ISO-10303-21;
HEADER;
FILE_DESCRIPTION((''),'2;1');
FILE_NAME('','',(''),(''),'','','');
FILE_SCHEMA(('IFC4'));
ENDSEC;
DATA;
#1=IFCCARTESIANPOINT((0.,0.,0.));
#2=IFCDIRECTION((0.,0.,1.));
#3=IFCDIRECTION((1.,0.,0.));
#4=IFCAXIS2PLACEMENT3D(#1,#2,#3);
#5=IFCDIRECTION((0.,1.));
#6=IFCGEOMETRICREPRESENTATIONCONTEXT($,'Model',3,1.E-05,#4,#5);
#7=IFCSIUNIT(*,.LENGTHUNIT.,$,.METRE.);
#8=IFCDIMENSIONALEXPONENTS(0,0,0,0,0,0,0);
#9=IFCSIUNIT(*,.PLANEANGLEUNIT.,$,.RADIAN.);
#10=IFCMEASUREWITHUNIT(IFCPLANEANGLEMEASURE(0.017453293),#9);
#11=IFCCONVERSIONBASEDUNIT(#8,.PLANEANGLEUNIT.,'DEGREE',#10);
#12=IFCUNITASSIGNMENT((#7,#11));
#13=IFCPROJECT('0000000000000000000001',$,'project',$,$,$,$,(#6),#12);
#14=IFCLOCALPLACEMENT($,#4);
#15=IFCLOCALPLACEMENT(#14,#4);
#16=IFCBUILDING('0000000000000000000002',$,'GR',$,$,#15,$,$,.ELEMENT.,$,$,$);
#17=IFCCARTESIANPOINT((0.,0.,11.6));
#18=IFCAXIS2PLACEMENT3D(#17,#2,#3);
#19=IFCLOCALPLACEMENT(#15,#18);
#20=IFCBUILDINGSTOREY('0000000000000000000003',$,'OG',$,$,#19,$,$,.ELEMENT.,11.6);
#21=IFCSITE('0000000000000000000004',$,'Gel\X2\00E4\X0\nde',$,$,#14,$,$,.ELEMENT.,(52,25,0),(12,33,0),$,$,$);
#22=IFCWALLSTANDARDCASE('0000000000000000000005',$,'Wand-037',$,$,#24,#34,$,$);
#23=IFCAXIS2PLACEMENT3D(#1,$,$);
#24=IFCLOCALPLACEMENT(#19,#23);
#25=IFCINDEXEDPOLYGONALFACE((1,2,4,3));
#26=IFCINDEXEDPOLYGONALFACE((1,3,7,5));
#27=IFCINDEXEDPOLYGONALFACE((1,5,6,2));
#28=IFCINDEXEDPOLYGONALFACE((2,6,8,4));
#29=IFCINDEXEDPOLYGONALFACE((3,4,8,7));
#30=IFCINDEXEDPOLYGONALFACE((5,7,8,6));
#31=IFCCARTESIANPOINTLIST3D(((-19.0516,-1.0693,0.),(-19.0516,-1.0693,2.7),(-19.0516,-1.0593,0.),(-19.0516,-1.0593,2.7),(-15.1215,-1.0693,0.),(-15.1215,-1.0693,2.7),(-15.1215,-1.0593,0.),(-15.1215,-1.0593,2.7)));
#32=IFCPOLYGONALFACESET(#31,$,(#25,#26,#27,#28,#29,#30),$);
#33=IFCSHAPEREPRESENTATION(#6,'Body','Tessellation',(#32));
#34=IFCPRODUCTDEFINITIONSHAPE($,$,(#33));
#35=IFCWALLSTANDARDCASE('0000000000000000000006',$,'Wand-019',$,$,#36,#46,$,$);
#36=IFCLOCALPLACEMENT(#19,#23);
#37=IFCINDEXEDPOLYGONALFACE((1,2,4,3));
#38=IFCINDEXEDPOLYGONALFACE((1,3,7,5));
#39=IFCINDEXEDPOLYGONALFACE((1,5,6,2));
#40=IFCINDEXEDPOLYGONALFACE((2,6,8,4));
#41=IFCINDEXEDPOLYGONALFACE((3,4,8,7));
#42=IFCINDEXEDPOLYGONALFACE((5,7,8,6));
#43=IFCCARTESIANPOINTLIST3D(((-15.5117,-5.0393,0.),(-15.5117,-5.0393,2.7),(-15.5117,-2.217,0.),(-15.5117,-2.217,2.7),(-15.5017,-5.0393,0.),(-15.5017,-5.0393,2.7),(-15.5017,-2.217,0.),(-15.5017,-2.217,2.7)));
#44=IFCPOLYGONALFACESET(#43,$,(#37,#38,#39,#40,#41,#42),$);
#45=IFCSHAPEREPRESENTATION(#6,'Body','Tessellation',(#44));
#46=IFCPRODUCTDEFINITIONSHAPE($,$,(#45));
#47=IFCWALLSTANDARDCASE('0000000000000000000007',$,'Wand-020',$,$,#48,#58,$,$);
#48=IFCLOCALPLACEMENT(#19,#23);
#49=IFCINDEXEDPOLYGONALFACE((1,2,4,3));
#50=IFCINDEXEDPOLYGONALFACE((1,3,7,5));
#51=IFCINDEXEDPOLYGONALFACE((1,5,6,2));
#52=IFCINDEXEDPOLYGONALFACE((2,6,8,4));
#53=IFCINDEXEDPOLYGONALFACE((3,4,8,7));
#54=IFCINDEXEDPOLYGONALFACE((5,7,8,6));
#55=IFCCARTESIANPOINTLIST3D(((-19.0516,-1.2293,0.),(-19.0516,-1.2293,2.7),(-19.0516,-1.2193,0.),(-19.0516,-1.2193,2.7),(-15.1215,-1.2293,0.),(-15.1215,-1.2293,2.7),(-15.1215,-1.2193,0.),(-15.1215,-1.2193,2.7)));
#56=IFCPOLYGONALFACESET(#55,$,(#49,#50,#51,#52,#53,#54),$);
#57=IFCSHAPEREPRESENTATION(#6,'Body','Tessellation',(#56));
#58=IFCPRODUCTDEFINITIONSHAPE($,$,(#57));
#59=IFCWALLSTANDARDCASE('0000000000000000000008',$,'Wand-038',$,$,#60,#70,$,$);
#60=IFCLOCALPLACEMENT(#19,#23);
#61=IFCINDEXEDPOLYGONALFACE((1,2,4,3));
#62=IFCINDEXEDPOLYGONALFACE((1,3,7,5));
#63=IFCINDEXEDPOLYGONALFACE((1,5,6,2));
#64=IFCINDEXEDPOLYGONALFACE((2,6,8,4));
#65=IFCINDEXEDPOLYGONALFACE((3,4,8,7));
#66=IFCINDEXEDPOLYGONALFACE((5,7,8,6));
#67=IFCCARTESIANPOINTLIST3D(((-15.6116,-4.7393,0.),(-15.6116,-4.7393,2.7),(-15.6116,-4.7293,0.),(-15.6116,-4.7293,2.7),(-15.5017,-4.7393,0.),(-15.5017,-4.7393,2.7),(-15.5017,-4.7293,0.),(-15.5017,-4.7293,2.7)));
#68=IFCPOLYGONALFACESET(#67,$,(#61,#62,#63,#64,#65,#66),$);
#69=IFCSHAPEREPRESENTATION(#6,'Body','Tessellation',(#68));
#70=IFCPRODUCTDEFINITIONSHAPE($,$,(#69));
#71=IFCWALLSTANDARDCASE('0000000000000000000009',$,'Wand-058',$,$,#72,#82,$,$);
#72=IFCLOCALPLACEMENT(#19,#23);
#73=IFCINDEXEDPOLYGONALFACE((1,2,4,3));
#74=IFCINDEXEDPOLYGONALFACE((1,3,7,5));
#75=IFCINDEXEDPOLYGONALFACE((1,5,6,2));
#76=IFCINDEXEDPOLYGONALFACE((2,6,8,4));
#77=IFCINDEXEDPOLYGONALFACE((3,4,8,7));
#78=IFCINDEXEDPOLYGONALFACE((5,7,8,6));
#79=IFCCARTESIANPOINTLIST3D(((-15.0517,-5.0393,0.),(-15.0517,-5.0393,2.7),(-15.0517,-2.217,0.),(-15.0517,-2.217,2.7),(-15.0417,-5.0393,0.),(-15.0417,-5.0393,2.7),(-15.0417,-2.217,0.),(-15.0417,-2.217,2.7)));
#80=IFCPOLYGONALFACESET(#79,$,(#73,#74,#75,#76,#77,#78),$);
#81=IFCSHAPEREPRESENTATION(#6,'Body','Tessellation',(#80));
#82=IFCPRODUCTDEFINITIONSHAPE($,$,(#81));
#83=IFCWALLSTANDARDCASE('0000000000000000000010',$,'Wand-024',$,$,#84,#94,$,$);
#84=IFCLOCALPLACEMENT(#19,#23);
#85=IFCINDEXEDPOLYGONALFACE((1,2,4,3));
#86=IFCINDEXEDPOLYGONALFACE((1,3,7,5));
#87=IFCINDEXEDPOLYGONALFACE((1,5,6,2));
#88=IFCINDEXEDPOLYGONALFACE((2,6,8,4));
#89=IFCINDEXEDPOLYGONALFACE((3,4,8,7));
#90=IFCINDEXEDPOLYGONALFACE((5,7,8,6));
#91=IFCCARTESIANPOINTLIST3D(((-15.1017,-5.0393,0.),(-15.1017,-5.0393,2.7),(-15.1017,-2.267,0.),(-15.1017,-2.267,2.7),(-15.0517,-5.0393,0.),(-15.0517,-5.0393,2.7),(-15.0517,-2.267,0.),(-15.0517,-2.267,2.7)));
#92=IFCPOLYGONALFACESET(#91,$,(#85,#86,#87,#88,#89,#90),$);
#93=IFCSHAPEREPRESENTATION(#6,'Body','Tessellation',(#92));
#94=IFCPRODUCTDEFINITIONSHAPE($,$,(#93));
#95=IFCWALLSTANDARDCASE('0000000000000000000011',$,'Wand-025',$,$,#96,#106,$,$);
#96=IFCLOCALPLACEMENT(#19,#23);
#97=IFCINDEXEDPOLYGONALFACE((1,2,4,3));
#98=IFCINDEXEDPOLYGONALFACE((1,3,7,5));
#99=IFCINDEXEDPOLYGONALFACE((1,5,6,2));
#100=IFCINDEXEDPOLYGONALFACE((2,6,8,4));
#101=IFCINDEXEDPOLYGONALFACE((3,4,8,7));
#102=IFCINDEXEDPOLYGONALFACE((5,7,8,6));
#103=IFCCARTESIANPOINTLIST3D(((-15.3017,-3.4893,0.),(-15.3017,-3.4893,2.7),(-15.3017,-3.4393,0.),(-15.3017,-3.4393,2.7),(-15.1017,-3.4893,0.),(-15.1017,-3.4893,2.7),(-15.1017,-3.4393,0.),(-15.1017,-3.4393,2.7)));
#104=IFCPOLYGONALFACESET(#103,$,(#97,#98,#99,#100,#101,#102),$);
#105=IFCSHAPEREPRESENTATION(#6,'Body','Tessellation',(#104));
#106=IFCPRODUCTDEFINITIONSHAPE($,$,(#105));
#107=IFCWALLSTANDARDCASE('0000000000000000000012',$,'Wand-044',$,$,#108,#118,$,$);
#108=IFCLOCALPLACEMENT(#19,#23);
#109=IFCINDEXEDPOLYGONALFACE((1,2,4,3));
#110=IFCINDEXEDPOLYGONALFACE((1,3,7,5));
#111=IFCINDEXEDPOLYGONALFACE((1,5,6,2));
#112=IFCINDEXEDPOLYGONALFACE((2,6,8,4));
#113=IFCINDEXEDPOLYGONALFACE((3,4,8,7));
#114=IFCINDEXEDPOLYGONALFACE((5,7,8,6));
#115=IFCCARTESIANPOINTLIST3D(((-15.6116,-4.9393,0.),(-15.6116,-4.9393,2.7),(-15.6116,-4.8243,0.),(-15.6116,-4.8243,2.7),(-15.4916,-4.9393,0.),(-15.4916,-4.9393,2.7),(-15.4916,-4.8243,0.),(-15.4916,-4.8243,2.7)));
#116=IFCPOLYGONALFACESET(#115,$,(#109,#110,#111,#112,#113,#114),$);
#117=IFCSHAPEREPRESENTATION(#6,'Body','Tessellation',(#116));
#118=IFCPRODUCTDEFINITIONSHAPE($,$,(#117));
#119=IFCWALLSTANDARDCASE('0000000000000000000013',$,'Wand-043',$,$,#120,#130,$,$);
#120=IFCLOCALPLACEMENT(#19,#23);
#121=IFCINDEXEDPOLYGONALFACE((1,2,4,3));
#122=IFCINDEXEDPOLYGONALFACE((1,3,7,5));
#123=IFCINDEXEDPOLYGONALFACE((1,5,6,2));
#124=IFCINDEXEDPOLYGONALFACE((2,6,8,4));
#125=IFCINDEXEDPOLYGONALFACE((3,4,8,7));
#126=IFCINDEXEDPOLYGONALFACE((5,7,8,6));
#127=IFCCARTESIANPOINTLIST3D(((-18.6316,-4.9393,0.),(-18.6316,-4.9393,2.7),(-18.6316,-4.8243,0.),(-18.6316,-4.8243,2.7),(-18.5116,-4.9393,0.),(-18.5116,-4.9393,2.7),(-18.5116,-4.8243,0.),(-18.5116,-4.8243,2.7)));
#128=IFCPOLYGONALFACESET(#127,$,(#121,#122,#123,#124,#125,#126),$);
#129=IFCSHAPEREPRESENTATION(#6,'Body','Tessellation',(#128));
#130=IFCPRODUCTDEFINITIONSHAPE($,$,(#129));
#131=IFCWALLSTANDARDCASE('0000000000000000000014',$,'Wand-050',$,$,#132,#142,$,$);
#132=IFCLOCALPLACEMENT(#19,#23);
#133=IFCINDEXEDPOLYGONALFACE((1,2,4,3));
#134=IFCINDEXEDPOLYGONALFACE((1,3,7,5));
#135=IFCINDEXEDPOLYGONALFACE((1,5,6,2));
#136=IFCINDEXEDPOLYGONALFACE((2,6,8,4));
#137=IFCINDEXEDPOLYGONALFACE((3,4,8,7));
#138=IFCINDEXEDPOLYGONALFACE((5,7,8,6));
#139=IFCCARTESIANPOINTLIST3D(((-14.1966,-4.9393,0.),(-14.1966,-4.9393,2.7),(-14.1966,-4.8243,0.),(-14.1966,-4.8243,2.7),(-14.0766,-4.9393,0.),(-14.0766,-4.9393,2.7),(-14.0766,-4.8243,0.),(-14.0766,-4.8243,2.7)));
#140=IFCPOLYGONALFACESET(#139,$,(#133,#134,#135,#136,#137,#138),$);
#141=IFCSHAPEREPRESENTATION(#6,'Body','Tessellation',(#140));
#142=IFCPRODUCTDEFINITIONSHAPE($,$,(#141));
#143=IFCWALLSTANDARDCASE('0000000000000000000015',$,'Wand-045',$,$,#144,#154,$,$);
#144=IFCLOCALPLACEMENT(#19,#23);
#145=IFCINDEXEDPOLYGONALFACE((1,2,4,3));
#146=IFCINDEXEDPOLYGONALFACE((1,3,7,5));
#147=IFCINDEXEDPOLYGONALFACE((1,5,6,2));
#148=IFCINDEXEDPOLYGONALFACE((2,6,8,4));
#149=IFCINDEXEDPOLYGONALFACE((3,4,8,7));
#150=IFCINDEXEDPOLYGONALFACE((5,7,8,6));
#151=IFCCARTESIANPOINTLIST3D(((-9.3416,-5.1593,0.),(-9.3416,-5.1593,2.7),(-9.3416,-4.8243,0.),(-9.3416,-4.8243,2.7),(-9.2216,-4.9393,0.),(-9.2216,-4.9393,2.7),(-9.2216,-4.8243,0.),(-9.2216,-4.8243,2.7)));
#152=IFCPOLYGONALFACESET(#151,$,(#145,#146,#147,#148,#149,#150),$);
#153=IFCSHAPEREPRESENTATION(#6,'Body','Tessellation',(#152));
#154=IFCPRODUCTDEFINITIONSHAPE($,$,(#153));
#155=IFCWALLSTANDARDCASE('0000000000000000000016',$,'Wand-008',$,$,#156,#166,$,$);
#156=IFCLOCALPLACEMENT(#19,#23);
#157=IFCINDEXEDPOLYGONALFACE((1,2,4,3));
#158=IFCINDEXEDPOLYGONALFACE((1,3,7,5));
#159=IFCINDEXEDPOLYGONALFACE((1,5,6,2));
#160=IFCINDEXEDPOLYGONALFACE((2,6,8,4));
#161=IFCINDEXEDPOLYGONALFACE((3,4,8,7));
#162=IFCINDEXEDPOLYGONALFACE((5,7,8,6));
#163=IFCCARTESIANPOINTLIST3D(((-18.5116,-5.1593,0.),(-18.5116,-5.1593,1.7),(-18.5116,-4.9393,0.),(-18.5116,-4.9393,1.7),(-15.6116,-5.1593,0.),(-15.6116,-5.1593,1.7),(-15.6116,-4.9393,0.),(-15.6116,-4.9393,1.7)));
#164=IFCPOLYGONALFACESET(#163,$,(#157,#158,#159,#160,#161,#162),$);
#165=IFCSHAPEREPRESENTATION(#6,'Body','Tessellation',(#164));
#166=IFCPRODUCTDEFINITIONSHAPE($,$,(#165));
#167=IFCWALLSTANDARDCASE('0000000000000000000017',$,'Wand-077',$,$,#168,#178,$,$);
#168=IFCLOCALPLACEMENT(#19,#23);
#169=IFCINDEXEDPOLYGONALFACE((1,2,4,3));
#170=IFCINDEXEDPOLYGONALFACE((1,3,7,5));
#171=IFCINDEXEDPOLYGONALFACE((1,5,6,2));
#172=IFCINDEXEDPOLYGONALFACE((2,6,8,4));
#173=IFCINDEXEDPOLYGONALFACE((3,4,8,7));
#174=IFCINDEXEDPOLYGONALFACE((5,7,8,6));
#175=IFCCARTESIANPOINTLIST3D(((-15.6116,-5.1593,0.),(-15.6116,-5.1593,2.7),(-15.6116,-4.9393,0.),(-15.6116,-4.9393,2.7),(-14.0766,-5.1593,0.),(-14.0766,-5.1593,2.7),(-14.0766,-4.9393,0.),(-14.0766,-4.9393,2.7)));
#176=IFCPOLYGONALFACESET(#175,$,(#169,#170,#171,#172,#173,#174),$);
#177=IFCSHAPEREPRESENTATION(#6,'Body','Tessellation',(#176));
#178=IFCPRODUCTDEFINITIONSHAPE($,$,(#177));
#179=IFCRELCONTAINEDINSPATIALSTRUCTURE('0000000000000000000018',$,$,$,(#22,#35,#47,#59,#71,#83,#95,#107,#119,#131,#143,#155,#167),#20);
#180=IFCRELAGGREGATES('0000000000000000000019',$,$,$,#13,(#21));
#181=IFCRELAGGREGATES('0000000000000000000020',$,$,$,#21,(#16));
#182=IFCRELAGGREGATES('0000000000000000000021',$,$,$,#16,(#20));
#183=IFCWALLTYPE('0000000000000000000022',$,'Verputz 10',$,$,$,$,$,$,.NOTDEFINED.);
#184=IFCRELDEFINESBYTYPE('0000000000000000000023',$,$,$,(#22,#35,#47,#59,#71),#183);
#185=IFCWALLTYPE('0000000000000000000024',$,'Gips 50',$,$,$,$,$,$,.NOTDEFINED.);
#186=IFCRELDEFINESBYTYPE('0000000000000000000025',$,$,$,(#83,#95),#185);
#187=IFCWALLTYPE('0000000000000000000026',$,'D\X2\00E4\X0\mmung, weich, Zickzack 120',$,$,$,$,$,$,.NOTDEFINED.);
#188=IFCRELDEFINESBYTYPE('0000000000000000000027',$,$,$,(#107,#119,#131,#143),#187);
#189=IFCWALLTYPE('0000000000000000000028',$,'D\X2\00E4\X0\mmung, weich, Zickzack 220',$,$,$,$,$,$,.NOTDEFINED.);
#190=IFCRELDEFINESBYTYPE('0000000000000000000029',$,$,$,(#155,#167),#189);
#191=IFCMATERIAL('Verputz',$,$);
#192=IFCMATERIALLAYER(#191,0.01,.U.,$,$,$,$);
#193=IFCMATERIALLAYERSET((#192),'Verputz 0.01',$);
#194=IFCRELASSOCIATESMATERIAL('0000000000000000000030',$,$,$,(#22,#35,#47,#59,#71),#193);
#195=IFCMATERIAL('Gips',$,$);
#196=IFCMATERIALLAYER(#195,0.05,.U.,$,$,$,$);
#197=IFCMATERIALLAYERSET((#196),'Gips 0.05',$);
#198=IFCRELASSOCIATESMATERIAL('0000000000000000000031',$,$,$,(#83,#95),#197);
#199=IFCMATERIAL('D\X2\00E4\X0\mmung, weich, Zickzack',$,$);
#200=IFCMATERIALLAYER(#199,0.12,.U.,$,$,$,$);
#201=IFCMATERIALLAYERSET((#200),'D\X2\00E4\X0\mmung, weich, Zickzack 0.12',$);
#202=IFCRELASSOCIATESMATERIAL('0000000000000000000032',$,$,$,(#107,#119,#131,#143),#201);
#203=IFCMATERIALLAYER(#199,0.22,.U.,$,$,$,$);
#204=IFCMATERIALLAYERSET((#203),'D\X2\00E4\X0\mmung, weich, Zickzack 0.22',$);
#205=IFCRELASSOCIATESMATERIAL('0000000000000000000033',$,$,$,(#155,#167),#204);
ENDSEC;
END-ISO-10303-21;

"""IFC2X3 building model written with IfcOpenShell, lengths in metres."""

from ifc_helpers import new_model, entity, si_unit, converted_unit, direction, frame, origin_with_axes, place, context, project, spatial, polyline, outline, extrude, material, layer, layer_set, layer_usage, type_object, element, save


model = new_model("IFC2X3")

# Units and contexts
model_context = context("Model", 3, precision=1e-05, world=origin_with_axes(), true_north=direction((0.0, 1.0)))
ifc_project = project(units=[si_unit("LENGTHUNIT", "METRE"), converted_unit("PLANEANGLEUNIT", "DEGREE", entity("IfcPlaneAngleMeasure", 0.017453293), si_unit("PLANEANGLEUNIT", "RADIAN"), dimensions=[0, 0, 0, 0, 0, 0, 0])], contexts=[model_context])

# Site, building, storey
site_placement = place(None, origin_with_axes())
site = spatial("IfcSite", under=ifc_project, at=site_placement, Name="Gelände", CompositionType="ELEMENT", RefLatitude=(52, 25, 0), RefLongitude=(12, 33, 0))
building_placement = place(site_placement, origin_with_axes())
building = spatial("IfcBuilding", under=site, at=building_placement, Name="GR", CompositionType="ELEMENT")
storey_placement = place(building_placement, frame((0.0, 0.0, 11.6), z_axis=(0.0, 0.0, 1.0), x_axis=(1.0, 0.0, 0.0)))
storey = spatial("IfcBuildingStorey", under=building, at=storey_placement, Name="OG", CompositionType="ELEMENT", Elevation=11.6)

# Shared definitions
ifc_material_1 = material(Name="Dämmung, weich, Zickzack")

# Walls
ifc_material_2 = material(Name="Verputz")
ifc_layer_1 = layer(ifc_material_2, 0.01, ventilated="UNKNOWN")
ifc_layer_set_1 = layer_set([ifc_layer_1], Name="Verputz 0.01")
wall_type_1 = type_object("IfcWallType", Name="Verputz 10", PredefinedType="NOTDEFINED")
ifc_layer_usage_1 = layer_usage(ifc_layer_set_1, "AXIS2", "POSITIVE", 0.0)
wall_1_placement = place(storey_placement, frame((-19.0516, -1.0693, 0.0), z_axis=(0.0, 0.0, 1.0), x_axis=(1.0, 0.0, 0.0)))
element("IfcWallStandardCase", 1, at=wall_1_placement, inside=storey, type_object=wall_type_1, material=ifc_layer_usage_1, Name="Wand-037", context=model_context, shape_type="SweptSolid", body=[
    extrude(outline(polyline([(0.0, 0.0), (3.9302, 0.0), (3.9302, 0.01), (0.0, 0.01), (0.0, 0.0)])), origin_with_axes(), (0.0, 0.0, 1.0), 2.7),
])
ifc_layer_usage_2 = layer_usage(ifc_layer_set_1, "AXIS2", "POSITIVE", 0.0)
wall_2_placement = place(storey_placement, frame((-15.5017, -5.0393, 0.0), z_axis=(0.0, 0.0, 1.0), x_axis=(0.0, 1.0, 0.0)))
element("IfcWallStandardCase", 2, at=wall_2_placement, inside=storey, type_object=wall_type_1, material=ifc_layer_usage_2, Name="Wand-019", context=model_context, shape_type="SweptSolid", body=[
    extrude(outline(polyline([(0.0, 0.0), (2.8222, 0.0), (2.8222, 0.01), (0.0, 0.01), (0.0, 0.0)])), origin_with_axes(), (0.0, 0.0, 1.0), 2.7),
])
ifc_layer_usage_3 = layer_usage(ifc_layer_set_1, "AXIS2", "POSITIVE", 0.0)
wall_3_placement = place(storey_placement, frame((-15.1215, -1.2193, 0.0), z_axis=(0.0, 0.0, 1.0), x_axis=(-1.0, 0.0, 0.0)))
element("IfcWallStandardCase", 3, at=wall_3_placement, inside=storey, type_object=wall_type_1, material=ifc_layer_usage_3, Name="Wand-020", context=model_context, shape_type="SweptSolid", body=[
    extrude(outline(polyline([(0.0, 0.0), (3.9302, 0.0), (3.9302, 0.01), (0.0, 0.01), (0.0, 0.0)])), origin_with_axes(), (0.0, 0.0, 1.0), 2.7),
])
ifc_layer_usage_4 = layer_usage(ifc_layer_set_1, "AXIS2", "NEGATIVE", 0.0)
wall_4_placement = place(storey_placement, frame((-15.5017, -4.7393, 0.0), z_axis=(0.0, 0.0, 1.0), x_axis=(-1.0, 0.0, 0.0)))
element("IfcWallStandardCase", 4, at=wall_4_placement, inside=storey, type_object=wall_type_1, material=ifc_layer_usage_4, Name="Wand-038", context=model_context, shape_type="SweptSolid", body=[
    extrude(outline(polyline([(0.0, -0.01), (0.11, -0.01), (0.11, 0.0), (0.0, 0.0), (0.0, -0.01)])), origin_with_axes(), (0.0, 0.0, 1.0), 2.7),
])
ifc_layer_usage_5 = layer_usage(ifc_layer_set_1, "AXIS2", "POSITIVE", 0.0)
wall_5_placement = place(storey_placement, frame((-15.0517, -2.217, 0.0), z_axis=(0.0, 0.0, 1.0), x_axis=(0.0, -1.0, 0.0)))
element("IfcWallStandardCase", 5, at=wall_5_placement, inside=storey, type_object=wall_type_1, material=ifc_layer_usage_5, Name="Wand-058", context=model_context, shape_type="SweptSolid", body=[
    extrude(outline(polyline([(0.0, 0.0), (2.8222, 0.0), (2.8222, 0.01), (0.0, 0.01), (0.0, 0.0)])), origin_with_axes(), (0.0, 0.0, 1.0), 2.7),
])
ifc_material_3 = material(Name="Gips")
ifc_layer_2 = layer(ifc_material_3, 0.05, ventilated="UNKNOWN")
ifc_layer_set_2 = layer_set([ifc_layer_2], Name="Gips 0.05")
ifc_layer_usage_6 = layer_usage(ifc_layer_set_2, "AXIS2", "NEGATIVE", 0.0)
wall_type_2 = type_object("IfcWallType", Name="Gips 50", PredefinedType="NOTDEFINED")
wall_6_placement = place(storey_placement, frame((-15.1017, -5.0393, 0.0), z_axis=(0.0, 0.0, 1.0), x_axis=(0.0, 1.0, 0.0)))
element("IfcWallStandardCase", 6, at=wall_6_placement, inside=storey, type_object=wall_type_2, material=ifc_layer_usage_6, Name="Wand-024", context=model_context, shape_type="SweptSolid", body=[
    extrude(outline(polyline([(0.0, -0.05), (2.7722, -0.05), (2.7722, 0.0), (0.0, 0.0), (0.0, -0.05)])), origin_with_axes(), (0.0, 0.0, 1.0), 2.7),
])
ifc_layer_usage_7 = layer_usage(ifc_layer_set_2, "AXIS2", "NEGATIVE", 0.0)
wall_7_placement = place(storey_placement, frame((-15.1017, -3.4893, 0.0), z_axis=(0.0, 0.0, 1.0), x_axis=(-1.0, 0.0, 0.0)))
element("IfcWallStandardCase", 7, at=wall_7_placement, inside=storey, type_object=wall_type_2, material=ifc_layer_usage_7, Name="Wand-025", context=model_context, shape_type="SweptSolid", body=[
    extrude(outline(polyline([(0.0, -0.05), (0.2, -0.05), (0.2, 0.0), (0.0, 0.0), (0.0, -0.05)])), origin_with_axes(), (0.0, 0.0, 1.0), 2.7),
])

# Walls
ifc_layer_3 = layer(ifc_material_1, 0.12, ventilated="UNKNOWN")
ifc_layer_set_3 = layer_set([ifc_layer_3], Name="Dämmung, weich, Zickzack 0.12")
ifc_layer_usage_8 = layer_usage(ifc_layer_set_3, "AXIS2", "POSITIVE", 0.0)
wall_type_3 = type_object("IfcWallType", Name="Dämmung, weich, Zickzack 120", PredefinedType="NOTDEFINED")
wall_8_placement = place(storey_placement, frame((-15.6116, -4.8243, 0.0), z_axis=(0.0, 0.0, 1.0), x_axis=(0.0, -1.0, 0.0)))
element("IfcWallStandardCase", 8, at=wall_8_placement, inside=storey, type_object=wall_type_3, material=ifc_layer_usage_8, Name="Wand-044", context=model_context, shape_type="SweptSolid", body=[
    extrude(outline(polyline([(0.0, 0.0), (0.115, 0.0), (0.115, 0.12), (0.0, 0.12), (0.0, 0.0)])), origin_with_axes(), (0.0, 0.0, 1.0), 2.7),
])
ifc_layer_usage_9 = layer_usage(ifc_layer_set_3, "AXIS2", "NEGATIVE", 0.0)
wall_9_placement = place(storey_placement, frame((-18.5116, -4.8243, 0.0), z_axis=(0.0, 0.0, 1.0), x_axis=(0.0, -1.0, 0.0)))
element("IfcWallStandardCase", 9, at=wall_9_placement, inside=storey, type_object=wall_type_3, material=ifc_layer_usage_9, Name="Wand-043", context=model_context, shape_type="SweptSolid", body=[
    extrude(outline(polyline([(0.0, -0.12), (0.115, -0.12), (0.115, 0.0), (0.0, 0.0), (0.0, -0.12)])), origin_with_axes(), (0.0, 0.0, 1.0), 2.7),
])
ifc_layer_usage_10 = layer_usage(ifc_layer_set_3, "AXIS2", "POSITIVE", 0.0)
wall_10_placement = place(storey_placement, frame((-14.0766, -4.9393, 0.0), z_axis=(0.0, 0.0, 1.0), x_axis=(0.0, 1.0, 0.0)))
element("IfcWallStandardCase", 10, at=wall_10_placement, inside=storey, type_object=wall_type_3, material=ifc_layer_usage_10, Name="Wand-050", context=model_context, shape_type="SweptSolid", body=[
    extrude(outline(polyline([(0.0, 0.0), (0.115, 0.0), (0.115, 0.12), (0.0, 0.12), (0.0, 0.0)])), origin_with_axes(), (0.0, 0.0, 1.0), 2.7),
])
ifc_layer_usage_11 = layer_usage(ifc_layer_set_3, "AXIS2", "POSITIVE", 0.0)
wall_11_placement = place(storey_placement, frame((-9.3416, -4.8243, 0.0), z_axis=(0.0, 0.0, 1.0), x_axis=(0.0, -1.0, 0.0)))
element("IfcWallStandardCase", 11, at=wall_11_placement, inside=storey, type_object=wall_type_3, material=ifc_layer_usage_11, Name="Wand-045", context=model_context, shape_type="SweptSolid", body=[
    extrude(outline(polyline([(0.0, 0.0), (0.335, 0.0), (0.115, 0.12), (0.0, 0.12), (0.0, 0.0)])), origin_with_axes(), (0.0, 0.0, 1.0), 2.7),
])
ifc_layer_4 = layer(ifc_material_1, 0.22, ventilated="UNKNOWN")
ifc_layer_set_4 = layer_set([ifc_layer_4], Name="Dämmung, weich, Zickzack 0.22")
ifc_layer_usage_12 = layer_usage(ifc_layer_set_4, "AXIS2", "NEGATIVE", 0.0)
wall_type_4 = type_object("IfcWallType", Name="Dämmung, weich, Zickzack 220", PredefinedType="NOTDEFINED")
wall_12_placement = place(storey_placement, frame((-18.5116, -4.9393, 0.0), z_axis=(0.0, 0.0, 1.0), x_axis=(1.0, 0.0, 0.0)))
element("IfcWallStandardCase", 12, at=wall_12_placement, inside=storey, type_object=wall_type_4, material=ifc_layer_usage_12, Name="Wand-008", context=model_context, shape_type="SweptSolid", body=[
    extrude(outline(polyline([(0.0, -0.22), (2.9, -0.22), (2.9, 0.0), (0.0, 0.0), (0.0, -0.22)])), origin_with_axes(), (0.0, 0.0, 1.0), 1.7),
])
ifc_layer_usage_13 = layer_usage(ifc_layer_set_4, "AXIS2", "NEGATIVE", 0.0)
wall_13_placement = place(storey_placement, frame((-15.6116, -4.9393, 0.0), z_axis=(0.0, 0.0, 1.0), x_axis=(1.0, 0.0, 0.0)))
element("IfcWallStandardCase", 13, at=wall_13_placement, inside=storey, type_object=wall_type_4, material=ifc_layer_usage_13, Name="Wand-077", context=model_context, shape_type="SweptSolid", body=[
    extrude(outline(polyline([(0.0, -0.22), (1.535, -0.22), (1.535, 0.0), (0.0, 0.0), (0.0, -0.22)])), origin_with_axes(), (0.0, 0.0, 1.0), 2.7),
])

save(model, "model.ifc")
